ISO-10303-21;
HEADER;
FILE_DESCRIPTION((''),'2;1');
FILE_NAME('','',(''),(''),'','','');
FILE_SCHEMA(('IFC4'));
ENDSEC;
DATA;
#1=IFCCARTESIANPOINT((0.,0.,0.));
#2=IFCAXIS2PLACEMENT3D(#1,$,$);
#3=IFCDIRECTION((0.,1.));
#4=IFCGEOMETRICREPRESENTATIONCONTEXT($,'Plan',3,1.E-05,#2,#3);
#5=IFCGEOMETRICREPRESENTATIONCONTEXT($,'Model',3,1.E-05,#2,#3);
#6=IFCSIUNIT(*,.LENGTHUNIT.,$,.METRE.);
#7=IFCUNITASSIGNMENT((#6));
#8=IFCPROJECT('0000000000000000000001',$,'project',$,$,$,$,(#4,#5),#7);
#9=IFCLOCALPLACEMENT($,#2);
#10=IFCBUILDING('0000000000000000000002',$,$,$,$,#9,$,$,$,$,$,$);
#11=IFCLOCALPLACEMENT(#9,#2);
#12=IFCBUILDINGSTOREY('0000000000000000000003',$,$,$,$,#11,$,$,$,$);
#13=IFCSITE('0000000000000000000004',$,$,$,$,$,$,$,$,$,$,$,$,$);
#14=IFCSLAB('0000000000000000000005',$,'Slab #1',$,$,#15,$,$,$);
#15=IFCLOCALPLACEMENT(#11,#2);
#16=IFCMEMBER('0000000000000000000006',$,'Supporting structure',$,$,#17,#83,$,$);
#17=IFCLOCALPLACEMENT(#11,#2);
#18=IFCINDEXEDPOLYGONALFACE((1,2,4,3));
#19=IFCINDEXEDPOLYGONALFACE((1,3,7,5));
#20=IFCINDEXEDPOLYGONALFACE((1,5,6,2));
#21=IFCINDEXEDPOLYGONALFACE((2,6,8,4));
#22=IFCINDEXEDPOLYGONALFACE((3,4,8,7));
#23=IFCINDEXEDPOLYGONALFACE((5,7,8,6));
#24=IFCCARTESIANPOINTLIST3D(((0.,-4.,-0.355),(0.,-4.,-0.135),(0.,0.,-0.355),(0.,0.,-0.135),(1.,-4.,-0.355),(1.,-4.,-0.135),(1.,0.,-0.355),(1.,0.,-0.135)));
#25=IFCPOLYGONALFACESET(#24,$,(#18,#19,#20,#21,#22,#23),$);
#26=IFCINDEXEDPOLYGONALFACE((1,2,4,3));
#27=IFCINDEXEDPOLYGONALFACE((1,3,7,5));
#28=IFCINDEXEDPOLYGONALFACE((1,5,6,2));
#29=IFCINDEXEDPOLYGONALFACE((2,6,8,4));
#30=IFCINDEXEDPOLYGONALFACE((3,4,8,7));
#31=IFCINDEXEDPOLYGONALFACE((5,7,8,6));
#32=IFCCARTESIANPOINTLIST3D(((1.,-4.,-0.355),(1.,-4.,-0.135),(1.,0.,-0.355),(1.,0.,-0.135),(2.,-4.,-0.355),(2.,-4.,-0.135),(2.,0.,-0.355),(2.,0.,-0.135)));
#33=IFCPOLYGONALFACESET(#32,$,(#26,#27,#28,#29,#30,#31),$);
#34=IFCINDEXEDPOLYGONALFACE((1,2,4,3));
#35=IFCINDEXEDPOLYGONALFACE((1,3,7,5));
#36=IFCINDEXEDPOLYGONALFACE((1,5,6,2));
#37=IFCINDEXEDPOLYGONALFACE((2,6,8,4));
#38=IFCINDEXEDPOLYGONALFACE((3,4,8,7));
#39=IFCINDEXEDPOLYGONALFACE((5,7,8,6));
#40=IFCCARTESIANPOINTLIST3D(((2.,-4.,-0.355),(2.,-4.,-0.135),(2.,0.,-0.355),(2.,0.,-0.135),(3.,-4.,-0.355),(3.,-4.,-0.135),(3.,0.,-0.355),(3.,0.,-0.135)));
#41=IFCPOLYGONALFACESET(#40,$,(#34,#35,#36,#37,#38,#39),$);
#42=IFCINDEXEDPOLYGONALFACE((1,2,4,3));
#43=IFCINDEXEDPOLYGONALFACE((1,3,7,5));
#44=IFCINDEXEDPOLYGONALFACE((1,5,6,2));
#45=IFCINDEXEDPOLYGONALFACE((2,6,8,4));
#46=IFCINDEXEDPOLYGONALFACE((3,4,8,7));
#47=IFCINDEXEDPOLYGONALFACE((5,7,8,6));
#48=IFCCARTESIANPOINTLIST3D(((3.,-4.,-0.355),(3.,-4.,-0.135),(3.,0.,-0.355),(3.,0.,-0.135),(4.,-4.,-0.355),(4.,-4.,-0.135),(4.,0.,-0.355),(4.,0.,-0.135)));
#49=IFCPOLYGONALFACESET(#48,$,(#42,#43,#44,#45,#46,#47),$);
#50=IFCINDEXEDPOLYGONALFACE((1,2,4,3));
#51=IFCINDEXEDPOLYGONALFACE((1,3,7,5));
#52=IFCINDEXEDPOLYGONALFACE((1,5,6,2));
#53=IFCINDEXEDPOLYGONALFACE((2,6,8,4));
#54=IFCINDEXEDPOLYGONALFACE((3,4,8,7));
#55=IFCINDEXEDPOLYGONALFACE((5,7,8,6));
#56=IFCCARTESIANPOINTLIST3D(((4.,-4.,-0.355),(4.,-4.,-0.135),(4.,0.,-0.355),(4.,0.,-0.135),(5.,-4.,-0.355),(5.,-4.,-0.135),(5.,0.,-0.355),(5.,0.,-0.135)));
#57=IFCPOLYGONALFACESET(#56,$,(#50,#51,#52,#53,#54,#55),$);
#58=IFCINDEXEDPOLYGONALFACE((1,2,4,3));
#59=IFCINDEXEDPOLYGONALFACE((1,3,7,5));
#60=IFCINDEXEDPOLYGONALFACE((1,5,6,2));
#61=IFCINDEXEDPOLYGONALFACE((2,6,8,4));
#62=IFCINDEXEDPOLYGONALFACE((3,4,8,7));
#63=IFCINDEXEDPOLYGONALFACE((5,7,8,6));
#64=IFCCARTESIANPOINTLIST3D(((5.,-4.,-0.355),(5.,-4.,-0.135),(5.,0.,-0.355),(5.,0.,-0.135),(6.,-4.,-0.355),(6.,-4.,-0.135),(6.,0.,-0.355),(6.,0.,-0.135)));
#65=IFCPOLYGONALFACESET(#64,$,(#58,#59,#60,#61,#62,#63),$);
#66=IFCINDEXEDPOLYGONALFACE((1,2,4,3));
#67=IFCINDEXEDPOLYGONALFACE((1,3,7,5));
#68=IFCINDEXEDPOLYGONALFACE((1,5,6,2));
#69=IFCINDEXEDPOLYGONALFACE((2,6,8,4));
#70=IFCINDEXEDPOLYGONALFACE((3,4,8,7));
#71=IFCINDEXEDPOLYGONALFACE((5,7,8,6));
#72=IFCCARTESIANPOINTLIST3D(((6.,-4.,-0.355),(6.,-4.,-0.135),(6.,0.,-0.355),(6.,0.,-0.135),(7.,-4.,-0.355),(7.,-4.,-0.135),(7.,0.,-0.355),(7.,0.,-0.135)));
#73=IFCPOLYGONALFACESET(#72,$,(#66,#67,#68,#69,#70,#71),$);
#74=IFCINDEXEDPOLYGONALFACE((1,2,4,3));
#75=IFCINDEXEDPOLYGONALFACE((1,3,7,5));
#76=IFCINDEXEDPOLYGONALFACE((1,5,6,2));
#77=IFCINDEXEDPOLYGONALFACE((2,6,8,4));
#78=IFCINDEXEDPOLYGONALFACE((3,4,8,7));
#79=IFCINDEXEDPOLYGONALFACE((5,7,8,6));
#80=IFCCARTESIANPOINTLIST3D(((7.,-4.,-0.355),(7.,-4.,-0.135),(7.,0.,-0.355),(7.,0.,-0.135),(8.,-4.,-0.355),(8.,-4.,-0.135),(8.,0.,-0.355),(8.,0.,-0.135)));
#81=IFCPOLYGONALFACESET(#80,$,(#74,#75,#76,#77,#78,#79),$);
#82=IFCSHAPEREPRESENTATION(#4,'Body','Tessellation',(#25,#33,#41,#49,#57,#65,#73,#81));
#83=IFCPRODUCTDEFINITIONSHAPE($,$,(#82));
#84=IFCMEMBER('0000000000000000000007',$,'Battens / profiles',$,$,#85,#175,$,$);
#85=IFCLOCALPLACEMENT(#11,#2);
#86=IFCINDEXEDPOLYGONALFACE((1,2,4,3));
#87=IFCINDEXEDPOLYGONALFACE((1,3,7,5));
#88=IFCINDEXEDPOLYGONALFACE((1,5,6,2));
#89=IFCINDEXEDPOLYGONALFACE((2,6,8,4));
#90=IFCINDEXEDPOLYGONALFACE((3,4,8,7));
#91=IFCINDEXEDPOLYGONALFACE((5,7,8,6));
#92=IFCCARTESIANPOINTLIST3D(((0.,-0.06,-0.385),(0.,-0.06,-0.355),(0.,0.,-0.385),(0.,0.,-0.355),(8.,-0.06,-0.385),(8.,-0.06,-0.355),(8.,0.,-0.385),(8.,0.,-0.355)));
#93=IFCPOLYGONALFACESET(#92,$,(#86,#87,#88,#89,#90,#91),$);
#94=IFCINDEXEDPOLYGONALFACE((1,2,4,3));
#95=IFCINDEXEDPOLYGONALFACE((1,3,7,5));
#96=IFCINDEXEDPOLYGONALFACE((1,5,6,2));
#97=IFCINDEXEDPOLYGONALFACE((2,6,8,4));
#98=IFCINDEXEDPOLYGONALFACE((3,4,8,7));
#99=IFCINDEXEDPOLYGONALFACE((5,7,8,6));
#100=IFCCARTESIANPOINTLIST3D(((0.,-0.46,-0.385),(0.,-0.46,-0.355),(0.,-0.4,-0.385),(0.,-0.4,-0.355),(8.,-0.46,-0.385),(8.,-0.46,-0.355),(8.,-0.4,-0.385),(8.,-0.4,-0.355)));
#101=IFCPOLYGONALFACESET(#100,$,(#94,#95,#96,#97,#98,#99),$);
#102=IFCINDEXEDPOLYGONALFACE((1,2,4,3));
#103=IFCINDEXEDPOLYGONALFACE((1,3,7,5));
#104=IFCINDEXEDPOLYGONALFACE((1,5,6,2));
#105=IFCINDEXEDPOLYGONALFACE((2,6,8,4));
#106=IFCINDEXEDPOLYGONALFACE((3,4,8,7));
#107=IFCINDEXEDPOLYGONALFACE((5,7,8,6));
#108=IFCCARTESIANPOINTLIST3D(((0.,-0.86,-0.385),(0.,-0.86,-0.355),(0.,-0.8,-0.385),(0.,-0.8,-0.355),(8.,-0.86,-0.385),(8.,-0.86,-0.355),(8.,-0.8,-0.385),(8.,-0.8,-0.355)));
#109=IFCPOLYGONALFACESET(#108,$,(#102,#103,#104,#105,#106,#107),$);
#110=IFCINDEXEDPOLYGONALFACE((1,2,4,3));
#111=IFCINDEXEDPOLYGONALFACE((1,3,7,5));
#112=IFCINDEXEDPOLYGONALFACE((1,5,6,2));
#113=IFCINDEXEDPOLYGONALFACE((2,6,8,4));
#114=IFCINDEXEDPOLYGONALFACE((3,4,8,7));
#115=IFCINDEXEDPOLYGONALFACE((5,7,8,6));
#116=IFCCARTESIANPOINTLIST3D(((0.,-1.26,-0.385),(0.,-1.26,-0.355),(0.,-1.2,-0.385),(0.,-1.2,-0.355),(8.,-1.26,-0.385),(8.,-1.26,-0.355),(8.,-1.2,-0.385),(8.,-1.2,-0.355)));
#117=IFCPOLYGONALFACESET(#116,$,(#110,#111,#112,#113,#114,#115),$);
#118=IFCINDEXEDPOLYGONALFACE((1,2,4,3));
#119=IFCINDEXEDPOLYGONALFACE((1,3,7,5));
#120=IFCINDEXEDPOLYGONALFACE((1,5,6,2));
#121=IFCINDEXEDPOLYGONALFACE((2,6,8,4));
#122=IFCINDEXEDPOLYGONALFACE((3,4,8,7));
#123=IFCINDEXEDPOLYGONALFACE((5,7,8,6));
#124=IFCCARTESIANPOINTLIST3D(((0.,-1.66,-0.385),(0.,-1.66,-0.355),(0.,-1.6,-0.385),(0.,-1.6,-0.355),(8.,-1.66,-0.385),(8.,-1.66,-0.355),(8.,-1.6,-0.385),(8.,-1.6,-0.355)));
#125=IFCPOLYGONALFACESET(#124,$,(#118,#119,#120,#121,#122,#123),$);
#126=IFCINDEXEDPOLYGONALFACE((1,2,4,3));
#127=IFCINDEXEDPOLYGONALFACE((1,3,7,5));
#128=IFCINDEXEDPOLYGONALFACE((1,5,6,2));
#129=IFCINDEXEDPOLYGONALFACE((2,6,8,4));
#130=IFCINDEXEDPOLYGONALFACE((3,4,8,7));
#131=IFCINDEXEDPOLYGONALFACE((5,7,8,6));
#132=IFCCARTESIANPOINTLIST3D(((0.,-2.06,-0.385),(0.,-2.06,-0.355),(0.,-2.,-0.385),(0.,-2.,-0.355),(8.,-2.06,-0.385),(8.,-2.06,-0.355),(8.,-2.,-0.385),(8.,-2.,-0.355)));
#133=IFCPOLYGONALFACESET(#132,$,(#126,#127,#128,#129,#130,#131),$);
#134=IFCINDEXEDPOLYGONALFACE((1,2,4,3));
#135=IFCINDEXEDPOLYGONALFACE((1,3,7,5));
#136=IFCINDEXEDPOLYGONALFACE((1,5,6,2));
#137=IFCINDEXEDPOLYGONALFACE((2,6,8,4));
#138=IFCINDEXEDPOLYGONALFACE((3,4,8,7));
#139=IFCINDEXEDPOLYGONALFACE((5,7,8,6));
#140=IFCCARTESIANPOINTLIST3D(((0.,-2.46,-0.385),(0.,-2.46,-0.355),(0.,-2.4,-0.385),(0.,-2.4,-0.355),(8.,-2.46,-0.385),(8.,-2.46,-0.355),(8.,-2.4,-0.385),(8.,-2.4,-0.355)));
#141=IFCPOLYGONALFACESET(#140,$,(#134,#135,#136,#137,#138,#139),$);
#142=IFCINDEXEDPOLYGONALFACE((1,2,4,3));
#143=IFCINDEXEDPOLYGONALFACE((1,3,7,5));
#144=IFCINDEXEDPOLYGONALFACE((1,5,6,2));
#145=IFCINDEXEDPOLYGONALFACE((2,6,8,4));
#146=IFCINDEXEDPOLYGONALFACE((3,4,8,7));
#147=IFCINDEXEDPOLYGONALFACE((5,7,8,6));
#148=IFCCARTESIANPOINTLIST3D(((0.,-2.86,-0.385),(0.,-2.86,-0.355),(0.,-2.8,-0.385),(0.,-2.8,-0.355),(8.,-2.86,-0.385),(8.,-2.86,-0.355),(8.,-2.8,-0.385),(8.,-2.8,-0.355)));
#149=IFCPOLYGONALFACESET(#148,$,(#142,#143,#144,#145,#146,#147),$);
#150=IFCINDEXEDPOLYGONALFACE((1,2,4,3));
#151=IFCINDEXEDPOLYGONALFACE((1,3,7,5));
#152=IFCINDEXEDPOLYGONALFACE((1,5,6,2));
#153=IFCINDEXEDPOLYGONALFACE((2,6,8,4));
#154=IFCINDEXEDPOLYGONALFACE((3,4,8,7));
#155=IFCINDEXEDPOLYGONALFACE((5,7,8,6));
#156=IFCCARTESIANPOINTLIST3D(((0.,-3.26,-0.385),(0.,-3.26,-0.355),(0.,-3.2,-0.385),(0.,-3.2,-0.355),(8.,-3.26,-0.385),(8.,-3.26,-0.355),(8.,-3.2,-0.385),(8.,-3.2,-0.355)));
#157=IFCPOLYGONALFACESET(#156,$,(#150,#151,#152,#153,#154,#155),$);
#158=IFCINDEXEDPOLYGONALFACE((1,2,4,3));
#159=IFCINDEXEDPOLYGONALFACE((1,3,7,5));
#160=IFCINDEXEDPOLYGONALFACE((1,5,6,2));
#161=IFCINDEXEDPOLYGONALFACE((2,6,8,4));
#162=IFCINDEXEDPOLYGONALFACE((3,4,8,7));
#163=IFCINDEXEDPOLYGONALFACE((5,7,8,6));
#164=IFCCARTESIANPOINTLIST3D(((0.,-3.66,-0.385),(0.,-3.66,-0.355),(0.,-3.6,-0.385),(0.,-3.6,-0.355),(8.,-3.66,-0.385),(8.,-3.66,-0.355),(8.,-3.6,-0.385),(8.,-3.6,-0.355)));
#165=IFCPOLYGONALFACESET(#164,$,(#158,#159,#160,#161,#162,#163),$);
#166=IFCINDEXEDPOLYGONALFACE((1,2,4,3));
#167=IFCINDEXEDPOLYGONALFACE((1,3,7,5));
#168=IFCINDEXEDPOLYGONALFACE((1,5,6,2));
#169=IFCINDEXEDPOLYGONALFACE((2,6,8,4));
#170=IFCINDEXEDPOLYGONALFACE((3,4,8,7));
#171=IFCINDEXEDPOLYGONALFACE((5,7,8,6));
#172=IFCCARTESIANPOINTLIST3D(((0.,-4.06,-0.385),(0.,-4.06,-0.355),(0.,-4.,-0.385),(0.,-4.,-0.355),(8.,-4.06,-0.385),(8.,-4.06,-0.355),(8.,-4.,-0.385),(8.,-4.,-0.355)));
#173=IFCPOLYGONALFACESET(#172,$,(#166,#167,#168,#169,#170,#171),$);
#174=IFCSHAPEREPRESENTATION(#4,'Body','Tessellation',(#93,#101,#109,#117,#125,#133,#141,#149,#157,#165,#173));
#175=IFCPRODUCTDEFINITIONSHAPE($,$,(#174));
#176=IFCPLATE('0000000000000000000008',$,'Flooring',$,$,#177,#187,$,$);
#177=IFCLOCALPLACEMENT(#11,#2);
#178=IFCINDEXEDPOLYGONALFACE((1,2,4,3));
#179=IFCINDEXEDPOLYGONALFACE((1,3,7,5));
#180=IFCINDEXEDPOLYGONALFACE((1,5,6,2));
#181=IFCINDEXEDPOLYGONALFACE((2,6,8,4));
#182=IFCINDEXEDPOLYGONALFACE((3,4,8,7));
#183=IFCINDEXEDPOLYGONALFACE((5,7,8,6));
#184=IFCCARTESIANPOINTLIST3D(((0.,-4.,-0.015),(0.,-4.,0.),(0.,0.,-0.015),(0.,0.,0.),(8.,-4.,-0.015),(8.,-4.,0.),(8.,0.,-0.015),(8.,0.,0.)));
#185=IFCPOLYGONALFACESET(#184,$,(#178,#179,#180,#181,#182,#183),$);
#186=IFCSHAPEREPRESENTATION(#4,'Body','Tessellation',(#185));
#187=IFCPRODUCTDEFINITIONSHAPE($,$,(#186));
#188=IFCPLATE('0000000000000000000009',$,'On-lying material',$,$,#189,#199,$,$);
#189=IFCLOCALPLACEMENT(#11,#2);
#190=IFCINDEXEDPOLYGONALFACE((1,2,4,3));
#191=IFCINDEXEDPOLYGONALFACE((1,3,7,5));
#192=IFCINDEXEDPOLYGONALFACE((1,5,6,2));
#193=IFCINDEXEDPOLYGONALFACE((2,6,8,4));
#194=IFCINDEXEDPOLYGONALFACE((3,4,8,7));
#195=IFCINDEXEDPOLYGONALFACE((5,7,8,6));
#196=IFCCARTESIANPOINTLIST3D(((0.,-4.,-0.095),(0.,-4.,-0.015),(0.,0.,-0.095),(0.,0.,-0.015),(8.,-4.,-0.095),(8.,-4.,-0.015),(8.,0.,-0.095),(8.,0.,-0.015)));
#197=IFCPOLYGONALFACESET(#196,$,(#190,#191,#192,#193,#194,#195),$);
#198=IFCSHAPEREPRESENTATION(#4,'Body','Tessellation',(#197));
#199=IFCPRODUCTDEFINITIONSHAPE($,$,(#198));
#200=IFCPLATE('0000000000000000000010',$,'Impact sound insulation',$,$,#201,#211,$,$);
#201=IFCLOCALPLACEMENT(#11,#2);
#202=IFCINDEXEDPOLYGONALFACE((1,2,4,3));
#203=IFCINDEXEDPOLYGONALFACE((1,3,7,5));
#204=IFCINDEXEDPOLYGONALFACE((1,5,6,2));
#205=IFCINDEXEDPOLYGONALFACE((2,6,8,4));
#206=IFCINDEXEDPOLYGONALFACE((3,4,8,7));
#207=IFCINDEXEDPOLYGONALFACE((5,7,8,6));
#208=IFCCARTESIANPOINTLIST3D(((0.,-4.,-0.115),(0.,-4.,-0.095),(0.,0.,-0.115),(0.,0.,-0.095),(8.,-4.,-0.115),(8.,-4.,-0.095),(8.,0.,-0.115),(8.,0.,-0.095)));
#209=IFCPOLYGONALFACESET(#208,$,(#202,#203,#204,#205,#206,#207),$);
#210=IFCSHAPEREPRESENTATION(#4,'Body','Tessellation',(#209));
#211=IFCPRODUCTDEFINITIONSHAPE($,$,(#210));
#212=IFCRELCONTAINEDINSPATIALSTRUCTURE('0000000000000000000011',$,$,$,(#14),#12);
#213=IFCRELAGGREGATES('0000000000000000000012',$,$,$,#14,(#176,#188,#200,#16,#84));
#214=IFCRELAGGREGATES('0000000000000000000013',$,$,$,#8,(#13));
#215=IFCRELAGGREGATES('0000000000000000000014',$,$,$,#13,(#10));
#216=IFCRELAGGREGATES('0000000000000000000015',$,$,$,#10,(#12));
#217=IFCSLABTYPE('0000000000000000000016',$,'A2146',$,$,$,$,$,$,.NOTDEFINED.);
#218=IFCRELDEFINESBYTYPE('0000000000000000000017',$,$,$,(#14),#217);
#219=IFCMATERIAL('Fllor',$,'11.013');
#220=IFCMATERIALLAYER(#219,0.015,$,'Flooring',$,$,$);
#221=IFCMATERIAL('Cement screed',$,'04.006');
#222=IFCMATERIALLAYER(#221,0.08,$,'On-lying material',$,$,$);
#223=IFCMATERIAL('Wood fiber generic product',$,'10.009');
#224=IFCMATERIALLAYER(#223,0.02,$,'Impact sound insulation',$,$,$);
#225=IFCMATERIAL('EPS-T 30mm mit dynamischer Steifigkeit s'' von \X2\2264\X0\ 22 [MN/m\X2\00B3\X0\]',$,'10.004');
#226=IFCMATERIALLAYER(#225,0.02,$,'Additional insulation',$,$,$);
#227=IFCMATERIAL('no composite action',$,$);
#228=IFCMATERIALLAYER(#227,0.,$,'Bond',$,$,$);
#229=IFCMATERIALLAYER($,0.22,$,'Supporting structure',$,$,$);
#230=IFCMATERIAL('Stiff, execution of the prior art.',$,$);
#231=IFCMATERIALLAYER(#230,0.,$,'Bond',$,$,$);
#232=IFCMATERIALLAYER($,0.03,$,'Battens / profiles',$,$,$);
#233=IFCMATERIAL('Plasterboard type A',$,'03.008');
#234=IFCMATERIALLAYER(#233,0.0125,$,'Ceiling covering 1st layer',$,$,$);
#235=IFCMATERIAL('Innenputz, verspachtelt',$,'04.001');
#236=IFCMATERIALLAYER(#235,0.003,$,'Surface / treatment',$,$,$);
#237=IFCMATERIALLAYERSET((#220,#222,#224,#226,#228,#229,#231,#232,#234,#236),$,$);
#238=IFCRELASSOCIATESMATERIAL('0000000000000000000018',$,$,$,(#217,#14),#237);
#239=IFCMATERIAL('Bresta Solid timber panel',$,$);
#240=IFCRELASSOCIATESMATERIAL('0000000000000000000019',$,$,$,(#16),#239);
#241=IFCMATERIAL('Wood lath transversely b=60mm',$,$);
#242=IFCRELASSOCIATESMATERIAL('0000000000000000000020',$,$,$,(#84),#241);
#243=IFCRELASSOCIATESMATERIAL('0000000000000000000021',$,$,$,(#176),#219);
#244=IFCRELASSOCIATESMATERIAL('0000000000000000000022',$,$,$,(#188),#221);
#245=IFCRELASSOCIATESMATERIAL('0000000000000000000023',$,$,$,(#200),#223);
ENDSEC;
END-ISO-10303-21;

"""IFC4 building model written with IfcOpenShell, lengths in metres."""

from ifc_helpers import new_model, si_unit, direction, frame, frame_2d, origin, origin_with_axes, place, context, project, spatial, rectangle, extrude, material, layer, layer_set, type_object, element, aggregate, save


model = new_model("IFC4")

# Units and contexts
plan_context = context("Plan", 3, precision=1e-05, world=origin(), true_north=direction((0.0, 1.0)))
model_context = context("Model", 3, precision=1e-05, world=origin(), true_north=direction((0.0, 1.0)))
ifc_project = project(units=[si_unit("LENGTHUNIT", "METRE")], contexts=[plan_context, model_context])

# Site, building, storey
site = spatial("IfcSite", under=ifc_project)
building_placement = place(None, origin())
building = spatial("IfcBuilding", under=site, at=building_placement)
storey_placement = place(building_placement, origin())
storey = spatial("IfcBuildingStorey", under=building, at=storey_placement)

# Slab, members, plates
ifc_material_1 = material(Name="Fllor", Category="11.013")
ifc_layer_1 = layer(ifc_material_1, 0.015, Name="Flooring")
ifc_material_2 = material(Name="Cement screed", Category="04.006")
ifc_layer_2 = layer(ifc_material_2, 0.08, Name="On-lying material")
ifc_material_3 = material(Name="Wood fiber generic product", Category="10.009")
ifc_layer_3 = layer(ifc_material_3, 0.02, Name="Impact sound insulation")
ifc_material_4 = material(Name="EPS-T 30mm mit dynamischer Steifigkeit s' von ≤ 22 [MN/m³]", Category="10.004")
ifc_layer_4 = layer(ifc_material_4, 0.02, Name="Additional insulation")
ifc_material_5 = material(Name="no composite action")
ifc_layer_5 = layer(ifc_material_5, 0.0, Name="Bond")
ifc_layer_6 = layer(None, 0.22, Name="Supporting structure")
ifc_material_6 = material(Name="Stiff, execution of the prior art.")
ifc_layer_7 = layer(ifc_material_6, 0.0, Name="Bond")
ifc_layer_8 = layer(None, 0.03, Name="Battens / profiles")
ifc_material_7 = material(Name="Plasterboard type A", Category="03.008")
ifc_layer_9 = layer(ifc_material_7, 0.0125, Name="Ceiling covering 1st layer")
ifc_material_8 = material(Name="Innenputz, verspachtelt", Category="04.001")
ifc_layer_10 = layer(ifc_material_8, 0.003, Name="Surface / treatment")
ifc_layer_set = layer_set([ifc_layer_1, ifc_layer_2, ifc_layer_3, ifc_layer_4, ifc_layer_5, ifc_layer_6, ifc_layer_7, ifc_layer_8, ifc_layer_9, ifc_layer_10])
slab_type = type_object("IfcSlabType", Name="A2146", PredefinedType="NOTDEFINED", material=ifc_layer_set)
slab_placement = place(None, frame((0.0, 0.0, 0.0), z_axis=(0.0, 0.0, -1.0), x_axis=(1.0, 0.0, 0.0)))
slab = element("IfcSlab", 1, at=slab_placement, inside=storey, type_object=slab_type, material=ifc_layer_set, Name="Slab #1")
ifc_material_9 = material(Name="Bresta Solid timber panel")
member_1_placement = place(slab_placement, origin())
member_1 = element("IfcMember", 2, at=member_1_placement, material=ifc_material_9, Name="Supporting structure", context=plan_context, shape_type="SweptSolid", body=[
    extrude(rectangle(XDim=1.0, YDim=0.22, at=frame_2d((0.5, 0.11), x_axis=(1.0, 0.0))), frame((0.0, 4.0, 0.135), z_axis=(0.0, -1.0, 0.0), x_axis=(1.0, 0.0, 0.0)), (0.0, 0.0, 1.0), 4.0),
    extrude(rectangle(XDim=1.0, YDim=0.22, at=frame_2d((0.5, 0.11), x_axis=(1.0, 0.0))), frame((1.0, 4.0, 0.135), z_axis=(0.0, -1.0, 0.0), x_axis=(1.0, 0.0, 0.0)), (0.0, 0.0, 1.0), 4.0),
    extrude(rectangle(XDim=1.0, YDim=0.22, at=frame_2d((0.5, 0.11), x_axis=(1.0, 0.0))), frame((2.0, 4.0, 0.135), z_axis=(0.0, -1.0, 0.0), x_axis=(1.0, 0.0, 0.0)), (0.0, 0.0, 1.0), 4.0),
    extrude(rectangle(XDim=1.0, YDim=0.22, at=frame_2d((0.5, 0.11), x_axis=(1.0, 0.0))), frame((3.0, 4.0, 0.135), z_axis=(0.0, -1.0, 0.0), x_axis=(1.0, 0.0, 0.0)), (0.0, 0.0, 1.0), 4.0),
    extrude(rectangle(XDim=1.0, YDim=0.22, at=frame_2d((0.5, 0.11), x_axis=(1.0, 0.0))), frame((4.0, 4.0, 0.135), z_axis=(0.0, -1.0, 0.0), x_axis=(1.0, 0.0, 0.0)), (0.0, 0.0, 1.0), 4.0),
    extrude(rectangle(XDim=1.0, YDim=0.22, at=frame_2d((0.5, 0.11), x_axis=(1.0, 0.0))), frame((5.0, 4.0, 0.135), z_axis=(0.0, -1.0, 0.0), x_axis=(1.0, 0.0, 0.0)), (0.0, 0.0, 1.0), 4.0),
    extrude(rectangle(XDim=1.0, YDim=0.22, at=frame_2d((0.5, 0.11), x_axis=(1.0, 0.0))), frame((6.0, 4.0, 0.135), z_axis=(0.0, -1.0, 0.0), x_axis=(1.0, 0.0, 0.0)), (0.0, 0.0, 1.0), 4.0),
    extrude(rectangle(XDim=1.0, YDim=0.22, at=frame_2d((0.5, 0.11), x_axis=(1.0, 0.0))), frame((7.0, 4.0, 0.135), z_axis=(0.0, -1.0, 0.0), x_axis=(1.0, 0.0, 0.0)), (0.0, 0.0, 1.0), 4.0),
])
ifc_material_10 = material(Name="Wood lath transversely b=60mm")
member_2_placement = place(slab_placement, origin())
member_2 = element("IfcMember", 3, at=member_2_placement, material=ifc_material_10, Name="Battens / profiles", context=plan_context, shape_type="SweptSolid", body=[
    extrude(rectangle(XDim=0.06, YDim=0.03, at=frame_2d((0.03, 0.015), x_axis=(1.0, 0.0))), frame((0.0, 0.0, 0.355), z_axis=(1.0, 0.0, 0.0), x_axis=(0.0, 1.0, 0.0)), (0.0, 0.0, 1.0), 8.0),
    extrude(rectangle(XDim=0.06, YDim=0.03, at=frame_2d((0.03, 0.015), x_axis=(1.0, 0.0))), frame((0.0, 0.4, 0.355), z_axis=(1.0, 0.0, 0.0), x_axis=(0.0, 1.0, 0.0)), (0.0, 0.0, 1.0), 8.0),
    extrude(rectangle(XDim=0.06, YDim=0.03, at=frame_2d((0.03, 0.015), x_axis=(1.0, 0.0))), frame((0.0, 0.8, 0.355), z_axis=(1.0, 0.0, 0.0), x_axis=(0.0, 1.0, 0.0)), (0.0, 0.0, 1.0), 8.0),
    extrude(rectangle(XDim=0.06, YDim=0.03, at=frame_2d((0.03, 0.015), x_axis=(1.0, 0.0))), frame((0.0, 1.2, 0.355), z_axis=(1.0, 0.0, 0.0), x_axis=(0.0, 1.0, 0.0)), (0.0, 0.0, 1.0), 8.0),
    extrude(rectangle(XDim=0.06, YDim=0.03, at=frame_2d((0.03, 0.015), x_axis=(1.0, 0.0))), frame((0.0, 1.6, 0.355), z_axis=(1.0, 0.0, 0.0), x_axis=(0.0, 1.0, 0.0)), (0.0, 0.0, 1.0), 8.0),
    extrude(rectangle(XDim=0.06, YDim=0.03, at=frame_2d((0.03, 0.015), x_axis=(1.0, 0.0))), frame((0.0, 2.0, 0.355), z_axis=(1.0, 0.0, 0.0), x_axis=(0.0, 1.0, 0.0)), (0.0, 0.0, 1.0), 8.0),
    extrude(rectangle(XDim=0.06, YDim=0.03, at=frame_2d((0.03, 0.015), x_axis=(1.0, 0.0))), frame((0.0, 2.4, 0.355), z_axis=(1.0, 0.0, 0.0), x_axis=(0.0, 1.0, 0.0)), (0.0, 0.0, 1.0), 8.0),
    extrude(rectangle(XDim=0.06, YDim=0.03, at=frame_2d((0.03, 0.015), x_axis=(1.0, 0.0))), frame((0.0, 2.8, 0.355), z_axis=(1.0, 0.0, 0.0), x_axis=(0.0, 1.0, 0.0)), (0.0, 0.0, 1.0), 8.0),
    extrude(rectangle(XDim=0.06, YDim=0.03, at=frame_2d((0.03, 0.015), x_axis=(1.0, 0.0))), frame((0.0, 3.2, 0.355), z_axis=(1.0, 0.0, 0.0), x_axis=(0.0, 1.0, 0.0)), (0.0, 0.0, 1.0), 8.0),
    extrude(rectangle(XDim=0.06, YDim=0.03, at=frame_2d((0.03, 0.015), x_axis=(1.0, 0.0))), frame((0.0, 3.6, 0.355), z_axis=(1.0, 0.0, 0.0), x_axis=(0.0, 1.0, 0.0)), (0.0, 0.0, 1.0), 8.0),
    extrude(rectangle(XDim=0.06, YDim=0.03, at=frame_2d((0.03, 0.015), x_axis=(1.0, 0.0))), frame((0.0, 4.0, 0.355), z_axis=(1.0, 0.0, 0.0), x_axis=(0.0, 1.0, 0.0)), (0.0, 0.0, 1.0), 8.0),
])
plate_1_placement = place(slab_placement, origin())
plate_1 = element("IfcPlate", 4, at=plate_1_placement, material=ifc_material_1, Name="Flooring", context=plan_context, shape_type="SweptSolid", body=[
    extrude(rectangle(XDim=8.0, YDim=4.0, at=frame_2d((4.0, 2.0), x_axis=(1.0, 0.0))), origin_with_axes(), (0.0, 0.0, 1.0), 0.015),
])
plate_2_placement = place(slab_placement, origin())
plate_2 = element("IfcPlate", 5, at=plate_2_placement, material=ifc_material_2, Name="On-lying material", context=plan_context, shape_type="SweptSolid", body=[
    extrude(rectangle(XDim=8.0, YDim=4.0, at=frame_2d((4.0, 2.0), x_axis=(1.0, 0.0))), frame((0.0, 0.0, 0.015), z_axis=(0.0, 0.0, 1.0), x_axis=(1.0, 0.0, 0.0)), (0.0, 0.0, 1.0), 0.08),
])
plate_3_placement = place(slab_placement, origin())
plate_3 = element("IfcPlate", 6, at=plate_3_placement, material=ifc_material_3, Name="Impact sound insulation", context=plan_context, shape_type="SweptSolid", body=[
    extrude(rectangle(XDim=8.0, YDim=4.0, at=frame_2d((4.0, 2.0), x_axis=(1.0, 0.0))), frame((0.0, 0.0, 0.095), z_axis=(0.0, 0.0, 1.0), x_axis=(1.0, 0.0, 0.0)), (0.0, 0.0, 1.0), 0.02),
])
aggregate(slab, [plate_1, plate_2, plate_3, member_1, member_2])

save(model, "model.ifc")
